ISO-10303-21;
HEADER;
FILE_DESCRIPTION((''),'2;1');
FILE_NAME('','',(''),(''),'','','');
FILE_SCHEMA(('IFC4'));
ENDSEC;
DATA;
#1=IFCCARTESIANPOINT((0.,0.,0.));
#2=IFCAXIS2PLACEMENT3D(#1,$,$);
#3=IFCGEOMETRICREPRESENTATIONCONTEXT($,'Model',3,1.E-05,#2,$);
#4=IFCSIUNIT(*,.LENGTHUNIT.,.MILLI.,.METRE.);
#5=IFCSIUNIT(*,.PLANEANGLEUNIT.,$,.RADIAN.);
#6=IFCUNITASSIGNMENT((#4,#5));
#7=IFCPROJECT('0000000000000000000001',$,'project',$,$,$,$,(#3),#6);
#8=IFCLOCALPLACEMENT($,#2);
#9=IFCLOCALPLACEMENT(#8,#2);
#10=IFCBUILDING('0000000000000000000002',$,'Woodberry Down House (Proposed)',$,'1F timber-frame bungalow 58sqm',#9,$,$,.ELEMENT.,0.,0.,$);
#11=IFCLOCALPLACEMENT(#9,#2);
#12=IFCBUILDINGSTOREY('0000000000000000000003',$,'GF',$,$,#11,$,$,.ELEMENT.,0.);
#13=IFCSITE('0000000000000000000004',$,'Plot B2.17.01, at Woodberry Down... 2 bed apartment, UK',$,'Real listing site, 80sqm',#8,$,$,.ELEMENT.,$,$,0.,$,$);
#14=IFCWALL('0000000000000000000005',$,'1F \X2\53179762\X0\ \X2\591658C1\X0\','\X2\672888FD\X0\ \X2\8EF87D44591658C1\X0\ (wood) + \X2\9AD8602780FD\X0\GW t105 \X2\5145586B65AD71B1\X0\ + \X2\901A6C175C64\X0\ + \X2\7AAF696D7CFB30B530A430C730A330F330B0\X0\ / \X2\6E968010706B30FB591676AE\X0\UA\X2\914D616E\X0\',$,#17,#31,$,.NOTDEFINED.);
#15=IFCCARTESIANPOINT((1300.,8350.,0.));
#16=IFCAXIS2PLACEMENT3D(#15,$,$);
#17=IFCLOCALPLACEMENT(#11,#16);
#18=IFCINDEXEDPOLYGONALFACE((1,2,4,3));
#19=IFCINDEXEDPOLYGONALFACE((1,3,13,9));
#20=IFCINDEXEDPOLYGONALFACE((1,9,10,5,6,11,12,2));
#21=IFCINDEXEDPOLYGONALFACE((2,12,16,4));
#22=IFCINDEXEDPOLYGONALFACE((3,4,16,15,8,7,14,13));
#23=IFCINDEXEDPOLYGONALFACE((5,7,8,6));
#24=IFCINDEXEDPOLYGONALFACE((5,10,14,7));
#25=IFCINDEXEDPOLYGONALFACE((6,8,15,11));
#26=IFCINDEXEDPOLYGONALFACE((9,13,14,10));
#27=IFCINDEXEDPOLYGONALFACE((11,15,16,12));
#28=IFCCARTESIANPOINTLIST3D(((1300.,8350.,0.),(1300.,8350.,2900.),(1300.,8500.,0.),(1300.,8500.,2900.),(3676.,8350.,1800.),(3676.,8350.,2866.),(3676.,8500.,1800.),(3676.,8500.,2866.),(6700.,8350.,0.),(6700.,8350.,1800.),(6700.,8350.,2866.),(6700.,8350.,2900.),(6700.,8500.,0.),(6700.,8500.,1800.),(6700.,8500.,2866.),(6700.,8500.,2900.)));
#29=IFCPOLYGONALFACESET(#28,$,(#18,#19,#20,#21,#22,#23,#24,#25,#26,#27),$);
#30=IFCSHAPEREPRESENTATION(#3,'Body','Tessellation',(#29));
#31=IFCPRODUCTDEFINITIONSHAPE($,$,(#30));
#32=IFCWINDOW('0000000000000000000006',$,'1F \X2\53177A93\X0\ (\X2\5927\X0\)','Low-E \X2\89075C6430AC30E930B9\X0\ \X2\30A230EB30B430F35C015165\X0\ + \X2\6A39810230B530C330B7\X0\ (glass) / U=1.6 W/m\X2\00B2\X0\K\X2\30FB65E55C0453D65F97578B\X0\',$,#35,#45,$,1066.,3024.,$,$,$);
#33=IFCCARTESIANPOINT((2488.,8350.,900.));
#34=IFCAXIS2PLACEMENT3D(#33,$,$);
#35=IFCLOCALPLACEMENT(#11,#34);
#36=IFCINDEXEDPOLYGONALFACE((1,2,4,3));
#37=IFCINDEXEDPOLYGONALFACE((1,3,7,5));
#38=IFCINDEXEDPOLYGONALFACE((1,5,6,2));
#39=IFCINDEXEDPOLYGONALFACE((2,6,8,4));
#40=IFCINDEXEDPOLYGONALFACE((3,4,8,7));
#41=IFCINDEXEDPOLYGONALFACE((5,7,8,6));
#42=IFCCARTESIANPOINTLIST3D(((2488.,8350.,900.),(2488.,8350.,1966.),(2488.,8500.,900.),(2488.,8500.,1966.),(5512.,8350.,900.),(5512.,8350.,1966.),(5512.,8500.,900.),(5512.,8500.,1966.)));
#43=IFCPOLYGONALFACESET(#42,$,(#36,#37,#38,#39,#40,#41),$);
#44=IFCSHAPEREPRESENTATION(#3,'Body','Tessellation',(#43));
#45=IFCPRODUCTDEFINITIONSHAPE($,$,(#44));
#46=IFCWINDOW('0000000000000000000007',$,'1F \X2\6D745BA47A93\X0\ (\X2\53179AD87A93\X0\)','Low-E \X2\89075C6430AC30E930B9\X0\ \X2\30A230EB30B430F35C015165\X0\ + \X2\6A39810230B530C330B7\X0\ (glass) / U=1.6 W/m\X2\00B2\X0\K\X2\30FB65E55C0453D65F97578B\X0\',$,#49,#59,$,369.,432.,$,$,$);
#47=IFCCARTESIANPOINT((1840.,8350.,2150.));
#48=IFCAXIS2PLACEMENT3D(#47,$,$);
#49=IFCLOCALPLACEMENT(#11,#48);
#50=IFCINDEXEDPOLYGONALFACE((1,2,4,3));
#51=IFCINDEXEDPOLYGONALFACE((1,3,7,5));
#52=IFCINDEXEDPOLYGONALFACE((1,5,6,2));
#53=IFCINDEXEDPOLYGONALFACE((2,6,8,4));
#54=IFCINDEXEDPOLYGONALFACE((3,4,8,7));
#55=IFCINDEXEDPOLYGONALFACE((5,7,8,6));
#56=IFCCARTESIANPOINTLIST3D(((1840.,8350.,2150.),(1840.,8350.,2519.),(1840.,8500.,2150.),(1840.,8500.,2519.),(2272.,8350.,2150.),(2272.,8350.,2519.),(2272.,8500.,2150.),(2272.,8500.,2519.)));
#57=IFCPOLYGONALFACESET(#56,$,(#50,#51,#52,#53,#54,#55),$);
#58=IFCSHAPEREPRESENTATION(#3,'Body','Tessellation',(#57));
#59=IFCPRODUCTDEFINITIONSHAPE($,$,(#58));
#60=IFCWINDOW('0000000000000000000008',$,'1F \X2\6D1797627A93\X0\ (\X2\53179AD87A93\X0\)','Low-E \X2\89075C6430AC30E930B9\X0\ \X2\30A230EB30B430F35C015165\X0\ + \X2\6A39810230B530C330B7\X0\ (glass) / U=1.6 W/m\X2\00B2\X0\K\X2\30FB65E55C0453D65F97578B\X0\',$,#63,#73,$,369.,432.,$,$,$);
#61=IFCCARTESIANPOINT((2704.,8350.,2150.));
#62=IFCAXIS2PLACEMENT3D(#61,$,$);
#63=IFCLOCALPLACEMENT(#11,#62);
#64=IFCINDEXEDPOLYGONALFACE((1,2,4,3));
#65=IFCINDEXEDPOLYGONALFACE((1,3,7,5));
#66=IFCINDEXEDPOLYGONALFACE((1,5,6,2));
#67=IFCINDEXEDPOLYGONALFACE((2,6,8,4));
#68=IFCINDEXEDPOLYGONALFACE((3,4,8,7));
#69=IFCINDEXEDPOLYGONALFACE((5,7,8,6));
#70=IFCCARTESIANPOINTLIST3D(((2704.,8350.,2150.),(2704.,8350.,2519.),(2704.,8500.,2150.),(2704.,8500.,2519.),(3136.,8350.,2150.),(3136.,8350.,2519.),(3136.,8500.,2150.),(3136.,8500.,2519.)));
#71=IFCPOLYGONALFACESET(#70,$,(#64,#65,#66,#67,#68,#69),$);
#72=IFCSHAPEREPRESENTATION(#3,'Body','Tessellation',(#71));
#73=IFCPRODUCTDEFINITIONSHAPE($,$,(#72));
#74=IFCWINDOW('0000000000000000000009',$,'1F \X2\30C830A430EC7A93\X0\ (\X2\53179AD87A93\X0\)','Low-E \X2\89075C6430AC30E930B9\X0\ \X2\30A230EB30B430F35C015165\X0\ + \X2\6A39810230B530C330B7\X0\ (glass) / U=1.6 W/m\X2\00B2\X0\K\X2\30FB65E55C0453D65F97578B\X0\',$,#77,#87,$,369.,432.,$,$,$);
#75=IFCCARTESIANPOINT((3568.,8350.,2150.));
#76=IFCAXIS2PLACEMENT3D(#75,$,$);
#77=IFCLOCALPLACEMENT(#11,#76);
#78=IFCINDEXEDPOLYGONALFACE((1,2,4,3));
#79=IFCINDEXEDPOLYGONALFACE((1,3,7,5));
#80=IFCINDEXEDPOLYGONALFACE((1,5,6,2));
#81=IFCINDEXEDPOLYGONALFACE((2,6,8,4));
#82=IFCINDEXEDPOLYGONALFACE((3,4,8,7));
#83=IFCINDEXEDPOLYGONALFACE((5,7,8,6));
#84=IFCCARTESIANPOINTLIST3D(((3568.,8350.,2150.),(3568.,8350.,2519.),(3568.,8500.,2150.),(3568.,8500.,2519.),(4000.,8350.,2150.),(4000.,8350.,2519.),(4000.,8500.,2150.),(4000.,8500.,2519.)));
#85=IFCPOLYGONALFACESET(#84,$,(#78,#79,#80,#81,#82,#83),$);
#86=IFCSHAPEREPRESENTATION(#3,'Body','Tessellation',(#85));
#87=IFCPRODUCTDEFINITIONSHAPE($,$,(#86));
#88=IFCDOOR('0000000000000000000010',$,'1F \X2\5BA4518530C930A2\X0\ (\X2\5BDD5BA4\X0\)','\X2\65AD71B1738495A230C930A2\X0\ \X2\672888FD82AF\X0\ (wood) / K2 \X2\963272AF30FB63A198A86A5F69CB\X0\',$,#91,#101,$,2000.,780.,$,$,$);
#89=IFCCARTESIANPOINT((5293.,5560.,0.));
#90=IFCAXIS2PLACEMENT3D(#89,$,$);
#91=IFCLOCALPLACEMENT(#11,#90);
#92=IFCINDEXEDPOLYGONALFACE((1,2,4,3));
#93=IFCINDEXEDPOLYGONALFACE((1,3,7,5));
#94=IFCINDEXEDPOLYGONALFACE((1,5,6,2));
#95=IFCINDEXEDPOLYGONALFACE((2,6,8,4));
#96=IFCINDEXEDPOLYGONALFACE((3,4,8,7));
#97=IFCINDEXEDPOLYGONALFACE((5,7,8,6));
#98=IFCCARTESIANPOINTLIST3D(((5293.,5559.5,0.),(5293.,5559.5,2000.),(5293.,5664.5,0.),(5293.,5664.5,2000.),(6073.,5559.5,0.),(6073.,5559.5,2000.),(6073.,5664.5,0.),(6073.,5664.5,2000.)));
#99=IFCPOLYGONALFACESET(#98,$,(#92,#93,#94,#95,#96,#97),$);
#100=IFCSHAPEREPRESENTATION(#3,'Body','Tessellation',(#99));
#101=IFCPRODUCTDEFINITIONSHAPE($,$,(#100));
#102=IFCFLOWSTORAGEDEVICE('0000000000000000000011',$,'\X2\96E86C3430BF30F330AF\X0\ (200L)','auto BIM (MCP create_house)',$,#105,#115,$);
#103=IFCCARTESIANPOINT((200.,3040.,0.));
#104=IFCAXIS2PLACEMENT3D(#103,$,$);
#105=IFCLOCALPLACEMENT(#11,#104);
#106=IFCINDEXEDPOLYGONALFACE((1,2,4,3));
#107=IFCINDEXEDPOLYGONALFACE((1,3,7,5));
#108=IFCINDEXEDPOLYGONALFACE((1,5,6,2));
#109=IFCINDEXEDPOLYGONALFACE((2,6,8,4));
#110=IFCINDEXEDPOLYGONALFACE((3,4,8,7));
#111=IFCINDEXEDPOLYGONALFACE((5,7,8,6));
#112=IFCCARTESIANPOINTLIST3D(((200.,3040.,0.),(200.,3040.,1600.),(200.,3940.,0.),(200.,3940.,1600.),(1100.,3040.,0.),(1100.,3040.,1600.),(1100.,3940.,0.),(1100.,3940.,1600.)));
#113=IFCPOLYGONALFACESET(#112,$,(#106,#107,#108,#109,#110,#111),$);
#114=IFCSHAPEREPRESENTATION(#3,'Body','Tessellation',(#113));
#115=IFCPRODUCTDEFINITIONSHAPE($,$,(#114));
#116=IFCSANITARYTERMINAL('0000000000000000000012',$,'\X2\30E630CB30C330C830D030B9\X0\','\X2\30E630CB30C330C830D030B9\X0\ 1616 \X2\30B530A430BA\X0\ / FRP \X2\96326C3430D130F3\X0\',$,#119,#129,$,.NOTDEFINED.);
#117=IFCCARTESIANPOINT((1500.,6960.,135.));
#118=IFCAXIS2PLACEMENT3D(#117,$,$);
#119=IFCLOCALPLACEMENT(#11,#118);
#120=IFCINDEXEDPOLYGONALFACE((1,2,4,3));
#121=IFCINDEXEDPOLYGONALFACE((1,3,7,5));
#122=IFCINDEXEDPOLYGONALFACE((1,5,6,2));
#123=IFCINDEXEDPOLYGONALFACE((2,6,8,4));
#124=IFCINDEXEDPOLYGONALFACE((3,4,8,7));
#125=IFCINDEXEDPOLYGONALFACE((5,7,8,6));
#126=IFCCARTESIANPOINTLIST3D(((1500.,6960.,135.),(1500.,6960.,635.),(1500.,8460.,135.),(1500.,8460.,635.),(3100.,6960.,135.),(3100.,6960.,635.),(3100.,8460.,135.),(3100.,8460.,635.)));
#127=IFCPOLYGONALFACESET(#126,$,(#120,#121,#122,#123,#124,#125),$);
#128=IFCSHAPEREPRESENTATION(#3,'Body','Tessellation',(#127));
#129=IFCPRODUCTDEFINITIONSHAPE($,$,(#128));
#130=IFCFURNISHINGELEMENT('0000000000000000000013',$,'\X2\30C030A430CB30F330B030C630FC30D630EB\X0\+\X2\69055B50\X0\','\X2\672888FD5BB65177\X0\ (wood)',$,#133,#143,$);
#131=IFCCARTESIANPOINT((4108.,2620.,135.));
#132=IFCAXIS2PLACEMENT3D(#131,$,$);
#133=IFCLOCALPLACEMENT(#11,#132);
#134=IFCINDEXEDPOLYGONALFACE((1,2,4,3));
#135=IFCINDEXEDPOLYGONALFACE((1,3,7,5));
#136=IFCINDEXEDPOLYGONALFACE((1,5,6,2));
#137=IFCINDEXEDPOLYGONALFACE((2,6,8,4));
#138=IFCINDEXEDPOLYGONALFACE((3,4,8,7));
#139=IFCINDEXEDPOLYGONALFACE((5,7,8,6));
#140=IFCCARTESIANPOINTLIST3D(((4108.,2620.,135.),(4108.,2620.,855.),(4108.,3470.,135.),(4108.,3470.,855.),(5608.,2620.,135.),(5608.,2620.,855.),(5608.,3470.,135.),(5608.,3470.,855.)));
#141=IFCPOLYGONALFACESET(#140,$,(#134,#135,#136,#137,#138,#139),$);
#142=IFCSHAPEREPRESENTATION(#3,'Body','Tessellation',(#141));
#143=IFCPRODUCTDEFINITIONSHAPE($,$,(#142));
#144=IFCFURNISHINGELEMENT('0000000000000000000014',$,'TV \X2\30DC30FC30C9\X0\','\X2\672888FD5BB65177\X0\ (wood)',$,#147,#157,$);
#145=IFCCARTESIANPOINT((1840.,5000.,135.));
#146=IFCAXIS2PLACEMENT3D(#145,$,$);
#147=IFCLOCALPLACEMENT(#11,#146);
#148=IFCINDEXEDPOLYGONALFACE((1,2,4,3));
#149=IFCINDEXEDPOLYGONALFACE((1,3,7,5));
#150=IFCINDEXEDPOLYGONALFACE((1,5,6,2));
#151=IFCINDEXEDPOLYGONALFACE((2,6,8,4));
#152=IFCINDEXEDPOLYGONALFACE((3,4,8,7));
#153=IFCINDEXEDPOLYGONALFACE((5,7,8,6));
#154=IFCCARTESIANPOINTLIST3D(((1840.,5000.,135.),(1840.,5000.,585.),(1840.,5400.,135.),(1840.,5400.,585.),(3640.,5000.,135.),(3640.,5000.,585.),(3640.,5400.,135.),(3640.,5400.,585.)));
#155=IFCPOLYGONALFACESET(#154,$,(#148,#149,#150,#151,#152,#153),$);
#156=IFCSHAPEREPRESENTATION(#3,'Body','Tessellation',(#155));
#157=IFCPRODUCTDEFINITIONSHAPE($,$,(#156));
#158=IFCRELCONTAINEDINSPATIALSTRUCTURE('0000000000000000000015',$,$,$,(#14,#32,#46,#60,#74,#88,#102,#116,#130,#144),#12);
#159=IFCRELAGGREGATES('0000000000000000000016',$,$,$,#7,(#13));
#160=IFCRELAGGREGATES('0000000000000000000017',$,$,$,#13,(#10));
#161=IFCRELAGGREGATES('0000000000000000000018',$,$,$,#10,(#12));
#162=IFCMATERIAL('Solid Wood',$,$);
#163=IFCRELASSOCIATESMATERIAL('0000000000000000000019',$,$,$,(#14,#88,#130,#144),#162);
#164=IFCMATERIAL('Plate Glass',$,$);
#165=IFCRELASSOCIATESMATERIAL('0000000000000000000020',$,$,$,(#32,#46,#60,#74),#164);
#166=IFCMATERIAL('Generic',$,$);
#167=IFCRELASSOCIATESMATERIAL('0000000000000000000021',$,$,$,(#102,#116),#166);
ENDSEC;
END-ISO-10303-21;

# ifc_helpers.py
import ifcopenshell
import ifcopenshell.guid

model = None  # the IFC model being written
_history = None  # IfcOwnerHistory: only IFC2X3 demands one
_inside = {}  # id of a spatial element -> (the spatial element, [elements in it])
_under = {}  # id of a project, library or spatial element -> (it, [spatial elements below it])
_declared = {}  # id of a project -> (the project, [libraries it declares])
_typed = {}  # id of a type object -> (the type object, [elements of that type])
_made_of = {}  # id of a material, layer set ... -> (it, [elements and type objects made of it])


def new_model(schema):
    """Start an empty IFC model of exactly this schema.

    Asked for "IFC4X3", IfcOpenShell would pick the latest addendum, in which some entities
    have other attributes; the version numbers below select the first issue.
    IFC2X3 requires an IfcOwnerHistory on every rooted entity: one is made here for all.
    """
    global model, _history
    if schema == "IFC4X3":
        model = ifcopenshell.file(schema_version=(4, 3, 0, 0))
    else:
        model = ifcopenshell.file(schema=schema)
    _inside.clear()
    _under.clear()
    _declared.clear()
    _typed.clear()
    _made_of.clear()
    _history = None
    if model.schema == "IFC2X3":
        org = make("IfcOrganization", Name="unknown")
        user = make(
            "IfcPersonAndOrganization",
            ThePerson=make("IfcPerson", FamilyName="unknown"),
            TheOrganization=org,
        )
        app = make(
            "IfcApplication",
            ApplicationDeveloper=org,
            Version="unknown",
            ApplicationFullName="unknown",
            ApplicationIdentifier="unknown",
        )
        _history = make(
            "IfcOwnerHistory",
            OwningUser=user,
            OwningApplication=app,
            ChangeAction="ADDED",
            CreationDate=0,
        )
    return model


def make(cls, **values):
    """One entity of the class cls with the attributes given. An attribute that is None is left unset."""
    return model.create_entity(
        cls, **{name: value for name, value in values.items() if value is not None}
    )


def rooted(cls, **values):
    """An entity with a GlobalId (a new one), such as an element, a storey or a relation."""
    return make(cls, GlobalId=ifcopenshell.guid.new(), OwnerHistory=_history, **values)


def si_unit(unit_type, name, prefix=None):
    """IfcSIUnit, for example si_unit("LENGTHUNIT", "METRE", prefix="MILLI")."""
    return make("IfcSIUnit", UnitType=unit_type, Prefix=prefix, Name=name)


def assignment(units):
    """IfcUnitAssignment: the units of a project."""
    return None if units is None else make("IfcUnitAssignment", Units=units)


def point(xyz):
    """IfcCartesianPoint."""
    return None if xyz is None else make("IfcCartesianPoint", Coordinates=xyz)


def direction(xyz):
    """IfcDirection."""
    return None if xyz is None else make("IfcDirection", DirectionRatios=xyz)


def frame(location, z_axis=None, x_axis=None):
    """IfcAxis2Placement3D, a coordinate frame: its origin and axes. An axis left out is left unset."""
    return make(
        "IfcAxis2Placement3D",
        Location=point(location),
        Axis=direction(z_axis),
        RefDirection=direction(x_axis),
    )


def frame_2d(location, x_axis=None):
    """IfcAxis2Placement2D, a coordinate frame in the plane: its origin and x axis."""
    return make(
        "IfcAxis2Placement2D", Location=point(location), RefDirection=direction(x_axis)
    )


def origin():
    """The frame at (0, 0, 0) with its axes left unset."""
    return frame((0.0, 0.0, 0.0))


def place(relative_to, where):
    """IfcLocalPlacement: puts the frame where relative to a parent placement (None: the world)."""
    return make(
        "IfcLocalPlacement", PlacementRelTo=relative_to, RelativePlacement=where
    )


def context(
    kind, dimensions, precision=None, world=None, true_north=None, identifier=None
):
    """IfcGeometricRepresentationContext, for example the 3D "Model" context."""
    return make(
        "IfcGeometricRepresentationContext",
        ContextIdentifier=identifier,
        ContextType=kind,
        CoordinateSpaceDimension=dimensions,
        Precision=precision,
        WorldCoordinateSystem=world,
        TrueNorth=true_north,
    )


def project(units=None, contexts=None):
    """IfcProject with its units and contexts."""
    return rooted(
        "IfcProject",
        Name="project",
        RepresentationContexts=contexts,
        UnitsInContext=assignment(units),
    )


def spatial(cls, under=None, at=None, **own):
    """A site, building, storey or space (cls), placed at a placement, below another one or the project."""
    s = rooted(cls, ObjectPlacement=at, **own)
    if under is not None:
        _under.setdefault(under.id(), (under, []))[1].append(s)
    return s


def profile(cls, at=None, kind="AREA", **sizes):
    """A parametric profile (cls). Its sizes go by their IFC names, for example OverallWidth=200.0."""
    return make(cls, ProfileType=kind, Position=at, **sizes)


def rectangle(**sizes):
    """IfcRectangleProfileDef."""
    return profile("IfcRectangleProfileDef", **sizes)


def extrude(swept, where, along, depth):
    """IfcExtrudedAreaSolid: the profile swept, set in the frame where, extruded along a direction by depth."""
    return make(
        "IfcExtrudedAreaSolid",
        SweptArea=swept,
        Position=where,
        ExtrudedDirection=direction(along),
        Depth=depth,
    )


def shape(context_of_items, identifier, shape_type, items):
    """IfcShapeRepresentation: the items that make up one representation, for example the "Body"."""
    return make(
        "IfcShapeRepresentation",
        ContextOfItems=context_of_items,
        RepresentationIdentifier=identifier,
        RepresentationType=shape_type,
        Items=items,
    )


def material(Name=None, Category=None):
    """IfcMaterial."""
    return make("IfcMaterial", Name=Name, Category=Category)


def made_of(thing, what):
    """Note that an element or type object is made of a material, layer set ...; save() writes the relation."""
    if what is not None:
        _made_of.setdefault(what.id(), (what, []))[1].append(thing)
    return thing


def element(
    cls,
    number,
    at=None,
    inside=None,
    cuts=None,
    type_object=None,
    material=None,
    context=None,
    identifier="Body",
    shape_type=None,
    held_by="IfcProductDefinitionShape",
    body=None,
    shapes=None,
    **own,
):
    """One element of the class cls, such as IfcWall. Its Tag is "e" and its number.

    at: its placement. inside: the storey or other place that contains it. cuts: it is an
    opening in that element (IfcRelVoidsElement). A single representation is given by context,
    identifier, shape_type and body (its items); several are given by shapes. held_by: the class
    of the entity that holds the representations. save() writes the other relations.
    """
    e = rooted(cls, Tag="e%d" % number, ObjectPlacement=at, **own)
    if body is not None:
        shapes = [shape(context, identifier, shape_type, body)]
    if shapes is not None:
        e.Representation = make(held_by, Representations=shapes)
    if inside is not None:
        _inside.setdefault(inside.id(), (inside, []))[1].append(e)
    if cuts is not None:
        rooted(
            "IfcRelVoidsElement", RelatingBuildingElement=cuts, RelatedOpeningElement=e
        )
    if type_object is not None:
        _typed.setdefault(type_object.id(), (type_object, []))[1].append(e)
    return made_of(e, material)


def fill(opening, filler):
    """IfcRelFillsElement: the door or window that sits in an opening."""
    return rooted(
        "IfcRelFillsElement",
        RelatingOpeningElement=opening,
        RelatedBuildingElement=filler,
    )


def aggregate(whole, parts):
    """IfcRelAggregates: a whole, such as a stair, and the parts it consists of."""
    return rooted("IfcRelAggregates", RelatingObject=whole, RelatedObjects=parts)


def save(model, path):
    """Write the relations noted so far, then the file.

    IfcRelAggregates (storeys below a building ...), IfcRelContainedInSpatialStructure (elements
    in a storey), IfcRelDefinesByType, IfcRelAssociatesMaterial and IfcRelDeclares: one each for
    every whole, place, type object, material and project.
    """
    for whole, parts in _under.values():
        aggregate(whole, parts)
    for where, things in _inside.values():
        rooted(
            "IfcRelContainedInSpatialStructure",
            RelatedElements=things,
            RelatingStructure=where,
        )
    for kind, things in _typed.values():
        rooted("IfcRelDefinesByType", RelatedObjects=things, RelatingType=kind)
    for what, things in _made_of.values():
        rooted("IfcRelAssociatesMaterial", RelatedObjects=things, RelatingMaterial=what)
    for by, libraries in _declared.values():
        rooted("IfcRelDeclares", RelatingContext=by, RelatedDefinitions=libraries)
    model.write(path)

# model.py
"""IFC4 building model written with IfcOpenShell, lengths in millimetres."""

from ifc_helpers import new_model, si_unit, frame, frame_2d, origin, place, context, project, spatial, rectangle, extrude, material, element, fill, save


model = new_model("IFC4")

# Units and contexts
model_context = context("Model", 3, precision=1e-05, world=origin())
ifc_project = project(units=[si_unit("LENGTHUNIT", "METRE", prefix="MILLI"), si_unit("PLANEANGLEUNIT", "RADIAN")], contexts=[model_context])

# Site, building, storey
site_placement = place(None, origin())
site = spatial("IfcSite", under=ifc_project, at=site_placement, Name="Plot B2.17.01, at Woodberry Down... 2 bed apartment, UK", ObjectType="Real listing site, 80sqm", CompositionType="ELEMENT", RefElevation=0.0)
building_placement = place(site_placement, origin())
building = spatial("IfcBuilding", under=site, at=building_placement, Name="Woodberry Down House (Proposed)", ObjectType="1F timber-frame bungalow 58sqm", CompositionType="ELEMENT", ElevationOfRefHeight=0.0, ElevationOfTerrain=0.0)
storey_placement = place(building_placement, origin())
storey = spatial("IfcBuildingStorey", under=building, at=storey_placement, Name="GF", CompositionType="ELEMENT", Elevation=0.0)

# Wall, openings, windows
ifc_material_1 = material(Name="Solid Wood")
wall_1_placement = place(storey_placement, frame((1300.0, 8350.0, 0.0)))
wall_1 = element("IfcWall", 1, at=wall_1_placement, inside=storey, material=ifc_material_1, Name="1F 北面 外壁", Description="木製 軸組外壁 (wood) + 高性能GW t105 充填断熱 + 通気層 + 窯業系サイディング / 準耐火・外皮UA配慮", PredefinedType="NOTDEFINED", context=model_context, shape_type="SweptSolid", body=[
    extrude(rectangle(XDim=5400.0, YDim=150.0, at=frame_2d((2700.0, 75.0))), frame((1300.0, 8350.0, 0.0)), (0.0, 0.0, 1.0), 2900.0),
])
opening_1_placement = place(storey_placement, frame((2488.0, 8350.0, 900.0)))
opening_1 = element("IfcOpeningElement", 2, at=opening_1_placement, cuts=wall_1, PredefinedType="NOTDEFINED", context=model_context, shape_type="SweptSolid", body=[
    extrude(rectangle(XDim=3024.0, YDim=150.0, at=frame_2d((1512.0, 75.0))), frame((2488.0, 8350.0, 900.0)), (0.0, 0.0, 1.0), 1066.0),
])
opening_2_placement = place(storey_placement, frame((1840.0, 8350.0, 2150.0)))
opening_2 = element("IfcOpeningElement", 3, at=opening_2_placement, cuts=wall_1, PredefinedType="NOTDEFINED", context=model_context, shape_type="SweptSolid", body=[
    extrude(rectangle(XDim=432.0, YDim=150.0, at=frame_2d((216.0, 75.0))), frame((1840.0, 8350.0, 2150.0)), (0.0, 0.0, 1.0), 369.0),
])
opening_3_placement = place(storey_placement, frame((2704.0, 8350.0, 2150.0)))
opening_3 = element("IfcOpeningElement", 4, at=opening_3_placement, cuts=wall_1, PredefinedType="NOTDEFINED", context=model_context, shape_type="SweptSolid", body=[
    extrude(rectangle(XDim=432.0, YDim=150.0, at=frame_2d((216.0, 75.0))), frame((2704.0, 8350.0, 2150.0)), (0.0, 0.0, 1.0), 369.0),
])
opening_4_placement = place(storey_placement, frame((3568.0, 8350.0, 2150.0)))
opening_4 = element("IfcOpeningElement", 5, at=opening_4_placement, cuts=wall_1, PredefinedType="NOTDEFINED", context=model_context, shape_type="SweptSolid", body=[
    extrude(rectangle(XDim=432.0, YDim=150.0, at=frame_2d((216.0, 75.0))), frame((3568.0, 8350.0, 2150.0)), (0.0, 0.0, 1.0), 369.0),
])
ifc_material_2 = material(Name="Plate Glass")
window_1_placement = place(storey_placement, frame((2488.0, 8350.0, 900.0)))
window_1 = element("IfcWindow", 6, at=window_1_placement, inside=storey, material=ifc_material_2, Name="1F 北窓 (大)", Description="Low-E 複層ガラス アルゴン封入 + 樹脂サッシ (glass) / U=1.6 W/m²K・日射取得型", OverallHeight=1066.0, OverallWidth=3024.0, context=model_context, shape_type="SweptSolid", body=[
    extrude(rectangle(XDim=3024.0, YDim=150.0, at=frame_2d((1512.0, 75.0))), frame((2488.0, 8350.0, 900.0)), (0.0, 0.0, 1.0), 1066.0),
])
fill(opening_1, window_1)
window_2_placement = place(storey_placement, frame((1840.0, 8350.0, 2150.0)))
window_2 = element("IfcWindow", 7, at=window_2_placement, inside=storey, material=ifc_material_2, Name="1F 浴室窓 (北高窓)", Description="Low-E 複層ガラス アルゴン封入 + 樹脂サッシ (glass) / U=1.6 W/m²K・日射取得型", OverallHeight=369.0, OverallWidth=432.0, context=model_context, shape_type="SweptSolid", body=[
    extrude(rectangle(XDim=432.0, YDim=150.0, at=frame_2d((216.0, 75.0))), frame((1840.0, 8350.0, 2150.0)), (0.0, 0.0, 1.0), 369.0),
])
fill(opening_2, window_2)
window_3_placement = place(storey_placement, frame((2704.0, 8350.0, 2150.0)))
window_3 = element("IfcWindow", 8, at=window_3_placement, inside=storey, material=ifc_material_2, Name="1F 洗面窓 (北高窓)", Description="Low-E 複層ガラス アルゴン封入 + 樹脂サッシ (glass) / U=1.6 W/m²K・日射取得型", OverallHeight=369.0, OverallWidth=432.0, context=model_context, shape_type="SweptSolid", body=[
    extrude(rectangle(XDim=432.0, YDim=150.0, at=frame_2d((216.0, 75.0))), frame((2704.0, 8350.0, 2150.0)), (0.0, 0.0, 1.0), 369.0),
])
fill(opening_3, window_3)
window_4_placement = place(storey_placement, frame((3568.0, 8350.0, 2150.0)))
window_4 = element("IfcWindow", 9, at=window_4_placement, inside=storey, material=ifc_material_2, Name="1F トイレ窓 (北高窓)", Description="Low-E 複層ガラス アルゴン封入 + 樹脂サッシ (glass) / U=1.6 W/m²K・日射取得型", OverallHeight=369.0, OverallWidth=432.0, context=model_context, shape_type="SweptSolid", body=[
    extrude(rectangle(XDim=432.0, YDim=150.0, at=frame_2d((216.0, 75.0))), frame((3568.0, 8350.0, 2150.0)), (0.0, 0.0, 1.0), 369.0),
])
fill(opening_4, window_4)

# Door
door_1_placement = place(storey_placement, frame((5293.0, 5560.0, 0.0)))
element("IfcDoor", 10, at=door_1_placement, inside=storey, material=ifc_material_1, Name="1F 室内ドア (寝室)", Description="断熱玄関ドア 木製芯 (wood) / K2 防犯・採風機構", OverallHeight=2000.0, OverallWidth=780.0, context=model_context, shape_type="SweptSolid", body=[
    extrude(rectangle(XDim=780.0, YDim=105.0, at=frame_2d((390.0, 52.0))), frame((5293.0, 5560.0, 0.0)), (0.0, 0.0, 1.0), 2000.0),
])

# Flow storage device
ifc_material_3 = material(Name="Generic")
flow_storage_device_placement = place(storey_placement, frame((200.0, 3040.0, 0.0)))
element("IfcFlowStorageDevice", 11, at=flow_storage_device_placement, inside=storey, material=ifc_material_3, Name="雨水タンク (200L)", Description="auto BIM (MCP create_house)", context=model_context, shape_type="SweptSolid", body=[
    extrude(rectangle(XDim=900.0, YDim=900.0, at=frame_2d((450.0, 450.0))), frame((200.0, 3040.0, 0.0)), (0.0, 0.0, 1.0), 1600.0),
])

# Sanitary terminal
sanitary_terminal_placement = place(storey_placement, frame((1500.0, 6960.0, 135.0)))
element("IfcSanitaryTerminal", 12, at=sanitary_terminal_placement, inside=storey, material=ifc_material_3, Name="ユニットバス", Description="ユニットバス 1616 サイズ / FRP 防水パン", PredefinedType="NOTDEFINED", context=model_context, shape_type="SweptSolid", body=[
    extrude(rectangle(XDim=1600.0, YDim=1500.0, at=frame_2d((800.0, 750.0))), frame((1500.0, 6960.0, 135.0)), (0.0, 0.0, 1.0), 500.0),
])

# Furnishing elements
furnishing_1_placement = place(storey_placement, frame((4108.0, 2620.0, 135.0)))
element("IfcFurnishingElement", 13, at=furnishing_1_placement, inside=storey, material=ifc_material_1, Name="ダイニングテーブル+椅子", Description="木製家具 (wood)", context=model_context, shape_type="SweptSolid", body=[
    extrude(rectangle(XDim=1500.0, YDim=850.0, at=frame_2d((750.0, 425.0))), frame((4108.0, 2620.0, 135.0)), (0.0, 0.0, 1.0), 720.0),
])
furnishing_2_placement = place(storey_placement, frame((1840.0, 5000.0, 135.0)))
element("IfcFurnishingElement", 14, at=furnishing_2_placement, inside=storey, material=ifc_material_1, Name="TV ボード", Description="木製家具 (wood)", context=model_context, shape_type="SweptSolid", body=[
    extrude(rectangle(XDim=1800.0, YDim=400.0, at=frame_2d((900.0, 200.0))), frame((1840.0, 5000.0, 135.0)), (0.0, 0.0, 1.0), 450.0),
])

save(model, "model.ifc")
